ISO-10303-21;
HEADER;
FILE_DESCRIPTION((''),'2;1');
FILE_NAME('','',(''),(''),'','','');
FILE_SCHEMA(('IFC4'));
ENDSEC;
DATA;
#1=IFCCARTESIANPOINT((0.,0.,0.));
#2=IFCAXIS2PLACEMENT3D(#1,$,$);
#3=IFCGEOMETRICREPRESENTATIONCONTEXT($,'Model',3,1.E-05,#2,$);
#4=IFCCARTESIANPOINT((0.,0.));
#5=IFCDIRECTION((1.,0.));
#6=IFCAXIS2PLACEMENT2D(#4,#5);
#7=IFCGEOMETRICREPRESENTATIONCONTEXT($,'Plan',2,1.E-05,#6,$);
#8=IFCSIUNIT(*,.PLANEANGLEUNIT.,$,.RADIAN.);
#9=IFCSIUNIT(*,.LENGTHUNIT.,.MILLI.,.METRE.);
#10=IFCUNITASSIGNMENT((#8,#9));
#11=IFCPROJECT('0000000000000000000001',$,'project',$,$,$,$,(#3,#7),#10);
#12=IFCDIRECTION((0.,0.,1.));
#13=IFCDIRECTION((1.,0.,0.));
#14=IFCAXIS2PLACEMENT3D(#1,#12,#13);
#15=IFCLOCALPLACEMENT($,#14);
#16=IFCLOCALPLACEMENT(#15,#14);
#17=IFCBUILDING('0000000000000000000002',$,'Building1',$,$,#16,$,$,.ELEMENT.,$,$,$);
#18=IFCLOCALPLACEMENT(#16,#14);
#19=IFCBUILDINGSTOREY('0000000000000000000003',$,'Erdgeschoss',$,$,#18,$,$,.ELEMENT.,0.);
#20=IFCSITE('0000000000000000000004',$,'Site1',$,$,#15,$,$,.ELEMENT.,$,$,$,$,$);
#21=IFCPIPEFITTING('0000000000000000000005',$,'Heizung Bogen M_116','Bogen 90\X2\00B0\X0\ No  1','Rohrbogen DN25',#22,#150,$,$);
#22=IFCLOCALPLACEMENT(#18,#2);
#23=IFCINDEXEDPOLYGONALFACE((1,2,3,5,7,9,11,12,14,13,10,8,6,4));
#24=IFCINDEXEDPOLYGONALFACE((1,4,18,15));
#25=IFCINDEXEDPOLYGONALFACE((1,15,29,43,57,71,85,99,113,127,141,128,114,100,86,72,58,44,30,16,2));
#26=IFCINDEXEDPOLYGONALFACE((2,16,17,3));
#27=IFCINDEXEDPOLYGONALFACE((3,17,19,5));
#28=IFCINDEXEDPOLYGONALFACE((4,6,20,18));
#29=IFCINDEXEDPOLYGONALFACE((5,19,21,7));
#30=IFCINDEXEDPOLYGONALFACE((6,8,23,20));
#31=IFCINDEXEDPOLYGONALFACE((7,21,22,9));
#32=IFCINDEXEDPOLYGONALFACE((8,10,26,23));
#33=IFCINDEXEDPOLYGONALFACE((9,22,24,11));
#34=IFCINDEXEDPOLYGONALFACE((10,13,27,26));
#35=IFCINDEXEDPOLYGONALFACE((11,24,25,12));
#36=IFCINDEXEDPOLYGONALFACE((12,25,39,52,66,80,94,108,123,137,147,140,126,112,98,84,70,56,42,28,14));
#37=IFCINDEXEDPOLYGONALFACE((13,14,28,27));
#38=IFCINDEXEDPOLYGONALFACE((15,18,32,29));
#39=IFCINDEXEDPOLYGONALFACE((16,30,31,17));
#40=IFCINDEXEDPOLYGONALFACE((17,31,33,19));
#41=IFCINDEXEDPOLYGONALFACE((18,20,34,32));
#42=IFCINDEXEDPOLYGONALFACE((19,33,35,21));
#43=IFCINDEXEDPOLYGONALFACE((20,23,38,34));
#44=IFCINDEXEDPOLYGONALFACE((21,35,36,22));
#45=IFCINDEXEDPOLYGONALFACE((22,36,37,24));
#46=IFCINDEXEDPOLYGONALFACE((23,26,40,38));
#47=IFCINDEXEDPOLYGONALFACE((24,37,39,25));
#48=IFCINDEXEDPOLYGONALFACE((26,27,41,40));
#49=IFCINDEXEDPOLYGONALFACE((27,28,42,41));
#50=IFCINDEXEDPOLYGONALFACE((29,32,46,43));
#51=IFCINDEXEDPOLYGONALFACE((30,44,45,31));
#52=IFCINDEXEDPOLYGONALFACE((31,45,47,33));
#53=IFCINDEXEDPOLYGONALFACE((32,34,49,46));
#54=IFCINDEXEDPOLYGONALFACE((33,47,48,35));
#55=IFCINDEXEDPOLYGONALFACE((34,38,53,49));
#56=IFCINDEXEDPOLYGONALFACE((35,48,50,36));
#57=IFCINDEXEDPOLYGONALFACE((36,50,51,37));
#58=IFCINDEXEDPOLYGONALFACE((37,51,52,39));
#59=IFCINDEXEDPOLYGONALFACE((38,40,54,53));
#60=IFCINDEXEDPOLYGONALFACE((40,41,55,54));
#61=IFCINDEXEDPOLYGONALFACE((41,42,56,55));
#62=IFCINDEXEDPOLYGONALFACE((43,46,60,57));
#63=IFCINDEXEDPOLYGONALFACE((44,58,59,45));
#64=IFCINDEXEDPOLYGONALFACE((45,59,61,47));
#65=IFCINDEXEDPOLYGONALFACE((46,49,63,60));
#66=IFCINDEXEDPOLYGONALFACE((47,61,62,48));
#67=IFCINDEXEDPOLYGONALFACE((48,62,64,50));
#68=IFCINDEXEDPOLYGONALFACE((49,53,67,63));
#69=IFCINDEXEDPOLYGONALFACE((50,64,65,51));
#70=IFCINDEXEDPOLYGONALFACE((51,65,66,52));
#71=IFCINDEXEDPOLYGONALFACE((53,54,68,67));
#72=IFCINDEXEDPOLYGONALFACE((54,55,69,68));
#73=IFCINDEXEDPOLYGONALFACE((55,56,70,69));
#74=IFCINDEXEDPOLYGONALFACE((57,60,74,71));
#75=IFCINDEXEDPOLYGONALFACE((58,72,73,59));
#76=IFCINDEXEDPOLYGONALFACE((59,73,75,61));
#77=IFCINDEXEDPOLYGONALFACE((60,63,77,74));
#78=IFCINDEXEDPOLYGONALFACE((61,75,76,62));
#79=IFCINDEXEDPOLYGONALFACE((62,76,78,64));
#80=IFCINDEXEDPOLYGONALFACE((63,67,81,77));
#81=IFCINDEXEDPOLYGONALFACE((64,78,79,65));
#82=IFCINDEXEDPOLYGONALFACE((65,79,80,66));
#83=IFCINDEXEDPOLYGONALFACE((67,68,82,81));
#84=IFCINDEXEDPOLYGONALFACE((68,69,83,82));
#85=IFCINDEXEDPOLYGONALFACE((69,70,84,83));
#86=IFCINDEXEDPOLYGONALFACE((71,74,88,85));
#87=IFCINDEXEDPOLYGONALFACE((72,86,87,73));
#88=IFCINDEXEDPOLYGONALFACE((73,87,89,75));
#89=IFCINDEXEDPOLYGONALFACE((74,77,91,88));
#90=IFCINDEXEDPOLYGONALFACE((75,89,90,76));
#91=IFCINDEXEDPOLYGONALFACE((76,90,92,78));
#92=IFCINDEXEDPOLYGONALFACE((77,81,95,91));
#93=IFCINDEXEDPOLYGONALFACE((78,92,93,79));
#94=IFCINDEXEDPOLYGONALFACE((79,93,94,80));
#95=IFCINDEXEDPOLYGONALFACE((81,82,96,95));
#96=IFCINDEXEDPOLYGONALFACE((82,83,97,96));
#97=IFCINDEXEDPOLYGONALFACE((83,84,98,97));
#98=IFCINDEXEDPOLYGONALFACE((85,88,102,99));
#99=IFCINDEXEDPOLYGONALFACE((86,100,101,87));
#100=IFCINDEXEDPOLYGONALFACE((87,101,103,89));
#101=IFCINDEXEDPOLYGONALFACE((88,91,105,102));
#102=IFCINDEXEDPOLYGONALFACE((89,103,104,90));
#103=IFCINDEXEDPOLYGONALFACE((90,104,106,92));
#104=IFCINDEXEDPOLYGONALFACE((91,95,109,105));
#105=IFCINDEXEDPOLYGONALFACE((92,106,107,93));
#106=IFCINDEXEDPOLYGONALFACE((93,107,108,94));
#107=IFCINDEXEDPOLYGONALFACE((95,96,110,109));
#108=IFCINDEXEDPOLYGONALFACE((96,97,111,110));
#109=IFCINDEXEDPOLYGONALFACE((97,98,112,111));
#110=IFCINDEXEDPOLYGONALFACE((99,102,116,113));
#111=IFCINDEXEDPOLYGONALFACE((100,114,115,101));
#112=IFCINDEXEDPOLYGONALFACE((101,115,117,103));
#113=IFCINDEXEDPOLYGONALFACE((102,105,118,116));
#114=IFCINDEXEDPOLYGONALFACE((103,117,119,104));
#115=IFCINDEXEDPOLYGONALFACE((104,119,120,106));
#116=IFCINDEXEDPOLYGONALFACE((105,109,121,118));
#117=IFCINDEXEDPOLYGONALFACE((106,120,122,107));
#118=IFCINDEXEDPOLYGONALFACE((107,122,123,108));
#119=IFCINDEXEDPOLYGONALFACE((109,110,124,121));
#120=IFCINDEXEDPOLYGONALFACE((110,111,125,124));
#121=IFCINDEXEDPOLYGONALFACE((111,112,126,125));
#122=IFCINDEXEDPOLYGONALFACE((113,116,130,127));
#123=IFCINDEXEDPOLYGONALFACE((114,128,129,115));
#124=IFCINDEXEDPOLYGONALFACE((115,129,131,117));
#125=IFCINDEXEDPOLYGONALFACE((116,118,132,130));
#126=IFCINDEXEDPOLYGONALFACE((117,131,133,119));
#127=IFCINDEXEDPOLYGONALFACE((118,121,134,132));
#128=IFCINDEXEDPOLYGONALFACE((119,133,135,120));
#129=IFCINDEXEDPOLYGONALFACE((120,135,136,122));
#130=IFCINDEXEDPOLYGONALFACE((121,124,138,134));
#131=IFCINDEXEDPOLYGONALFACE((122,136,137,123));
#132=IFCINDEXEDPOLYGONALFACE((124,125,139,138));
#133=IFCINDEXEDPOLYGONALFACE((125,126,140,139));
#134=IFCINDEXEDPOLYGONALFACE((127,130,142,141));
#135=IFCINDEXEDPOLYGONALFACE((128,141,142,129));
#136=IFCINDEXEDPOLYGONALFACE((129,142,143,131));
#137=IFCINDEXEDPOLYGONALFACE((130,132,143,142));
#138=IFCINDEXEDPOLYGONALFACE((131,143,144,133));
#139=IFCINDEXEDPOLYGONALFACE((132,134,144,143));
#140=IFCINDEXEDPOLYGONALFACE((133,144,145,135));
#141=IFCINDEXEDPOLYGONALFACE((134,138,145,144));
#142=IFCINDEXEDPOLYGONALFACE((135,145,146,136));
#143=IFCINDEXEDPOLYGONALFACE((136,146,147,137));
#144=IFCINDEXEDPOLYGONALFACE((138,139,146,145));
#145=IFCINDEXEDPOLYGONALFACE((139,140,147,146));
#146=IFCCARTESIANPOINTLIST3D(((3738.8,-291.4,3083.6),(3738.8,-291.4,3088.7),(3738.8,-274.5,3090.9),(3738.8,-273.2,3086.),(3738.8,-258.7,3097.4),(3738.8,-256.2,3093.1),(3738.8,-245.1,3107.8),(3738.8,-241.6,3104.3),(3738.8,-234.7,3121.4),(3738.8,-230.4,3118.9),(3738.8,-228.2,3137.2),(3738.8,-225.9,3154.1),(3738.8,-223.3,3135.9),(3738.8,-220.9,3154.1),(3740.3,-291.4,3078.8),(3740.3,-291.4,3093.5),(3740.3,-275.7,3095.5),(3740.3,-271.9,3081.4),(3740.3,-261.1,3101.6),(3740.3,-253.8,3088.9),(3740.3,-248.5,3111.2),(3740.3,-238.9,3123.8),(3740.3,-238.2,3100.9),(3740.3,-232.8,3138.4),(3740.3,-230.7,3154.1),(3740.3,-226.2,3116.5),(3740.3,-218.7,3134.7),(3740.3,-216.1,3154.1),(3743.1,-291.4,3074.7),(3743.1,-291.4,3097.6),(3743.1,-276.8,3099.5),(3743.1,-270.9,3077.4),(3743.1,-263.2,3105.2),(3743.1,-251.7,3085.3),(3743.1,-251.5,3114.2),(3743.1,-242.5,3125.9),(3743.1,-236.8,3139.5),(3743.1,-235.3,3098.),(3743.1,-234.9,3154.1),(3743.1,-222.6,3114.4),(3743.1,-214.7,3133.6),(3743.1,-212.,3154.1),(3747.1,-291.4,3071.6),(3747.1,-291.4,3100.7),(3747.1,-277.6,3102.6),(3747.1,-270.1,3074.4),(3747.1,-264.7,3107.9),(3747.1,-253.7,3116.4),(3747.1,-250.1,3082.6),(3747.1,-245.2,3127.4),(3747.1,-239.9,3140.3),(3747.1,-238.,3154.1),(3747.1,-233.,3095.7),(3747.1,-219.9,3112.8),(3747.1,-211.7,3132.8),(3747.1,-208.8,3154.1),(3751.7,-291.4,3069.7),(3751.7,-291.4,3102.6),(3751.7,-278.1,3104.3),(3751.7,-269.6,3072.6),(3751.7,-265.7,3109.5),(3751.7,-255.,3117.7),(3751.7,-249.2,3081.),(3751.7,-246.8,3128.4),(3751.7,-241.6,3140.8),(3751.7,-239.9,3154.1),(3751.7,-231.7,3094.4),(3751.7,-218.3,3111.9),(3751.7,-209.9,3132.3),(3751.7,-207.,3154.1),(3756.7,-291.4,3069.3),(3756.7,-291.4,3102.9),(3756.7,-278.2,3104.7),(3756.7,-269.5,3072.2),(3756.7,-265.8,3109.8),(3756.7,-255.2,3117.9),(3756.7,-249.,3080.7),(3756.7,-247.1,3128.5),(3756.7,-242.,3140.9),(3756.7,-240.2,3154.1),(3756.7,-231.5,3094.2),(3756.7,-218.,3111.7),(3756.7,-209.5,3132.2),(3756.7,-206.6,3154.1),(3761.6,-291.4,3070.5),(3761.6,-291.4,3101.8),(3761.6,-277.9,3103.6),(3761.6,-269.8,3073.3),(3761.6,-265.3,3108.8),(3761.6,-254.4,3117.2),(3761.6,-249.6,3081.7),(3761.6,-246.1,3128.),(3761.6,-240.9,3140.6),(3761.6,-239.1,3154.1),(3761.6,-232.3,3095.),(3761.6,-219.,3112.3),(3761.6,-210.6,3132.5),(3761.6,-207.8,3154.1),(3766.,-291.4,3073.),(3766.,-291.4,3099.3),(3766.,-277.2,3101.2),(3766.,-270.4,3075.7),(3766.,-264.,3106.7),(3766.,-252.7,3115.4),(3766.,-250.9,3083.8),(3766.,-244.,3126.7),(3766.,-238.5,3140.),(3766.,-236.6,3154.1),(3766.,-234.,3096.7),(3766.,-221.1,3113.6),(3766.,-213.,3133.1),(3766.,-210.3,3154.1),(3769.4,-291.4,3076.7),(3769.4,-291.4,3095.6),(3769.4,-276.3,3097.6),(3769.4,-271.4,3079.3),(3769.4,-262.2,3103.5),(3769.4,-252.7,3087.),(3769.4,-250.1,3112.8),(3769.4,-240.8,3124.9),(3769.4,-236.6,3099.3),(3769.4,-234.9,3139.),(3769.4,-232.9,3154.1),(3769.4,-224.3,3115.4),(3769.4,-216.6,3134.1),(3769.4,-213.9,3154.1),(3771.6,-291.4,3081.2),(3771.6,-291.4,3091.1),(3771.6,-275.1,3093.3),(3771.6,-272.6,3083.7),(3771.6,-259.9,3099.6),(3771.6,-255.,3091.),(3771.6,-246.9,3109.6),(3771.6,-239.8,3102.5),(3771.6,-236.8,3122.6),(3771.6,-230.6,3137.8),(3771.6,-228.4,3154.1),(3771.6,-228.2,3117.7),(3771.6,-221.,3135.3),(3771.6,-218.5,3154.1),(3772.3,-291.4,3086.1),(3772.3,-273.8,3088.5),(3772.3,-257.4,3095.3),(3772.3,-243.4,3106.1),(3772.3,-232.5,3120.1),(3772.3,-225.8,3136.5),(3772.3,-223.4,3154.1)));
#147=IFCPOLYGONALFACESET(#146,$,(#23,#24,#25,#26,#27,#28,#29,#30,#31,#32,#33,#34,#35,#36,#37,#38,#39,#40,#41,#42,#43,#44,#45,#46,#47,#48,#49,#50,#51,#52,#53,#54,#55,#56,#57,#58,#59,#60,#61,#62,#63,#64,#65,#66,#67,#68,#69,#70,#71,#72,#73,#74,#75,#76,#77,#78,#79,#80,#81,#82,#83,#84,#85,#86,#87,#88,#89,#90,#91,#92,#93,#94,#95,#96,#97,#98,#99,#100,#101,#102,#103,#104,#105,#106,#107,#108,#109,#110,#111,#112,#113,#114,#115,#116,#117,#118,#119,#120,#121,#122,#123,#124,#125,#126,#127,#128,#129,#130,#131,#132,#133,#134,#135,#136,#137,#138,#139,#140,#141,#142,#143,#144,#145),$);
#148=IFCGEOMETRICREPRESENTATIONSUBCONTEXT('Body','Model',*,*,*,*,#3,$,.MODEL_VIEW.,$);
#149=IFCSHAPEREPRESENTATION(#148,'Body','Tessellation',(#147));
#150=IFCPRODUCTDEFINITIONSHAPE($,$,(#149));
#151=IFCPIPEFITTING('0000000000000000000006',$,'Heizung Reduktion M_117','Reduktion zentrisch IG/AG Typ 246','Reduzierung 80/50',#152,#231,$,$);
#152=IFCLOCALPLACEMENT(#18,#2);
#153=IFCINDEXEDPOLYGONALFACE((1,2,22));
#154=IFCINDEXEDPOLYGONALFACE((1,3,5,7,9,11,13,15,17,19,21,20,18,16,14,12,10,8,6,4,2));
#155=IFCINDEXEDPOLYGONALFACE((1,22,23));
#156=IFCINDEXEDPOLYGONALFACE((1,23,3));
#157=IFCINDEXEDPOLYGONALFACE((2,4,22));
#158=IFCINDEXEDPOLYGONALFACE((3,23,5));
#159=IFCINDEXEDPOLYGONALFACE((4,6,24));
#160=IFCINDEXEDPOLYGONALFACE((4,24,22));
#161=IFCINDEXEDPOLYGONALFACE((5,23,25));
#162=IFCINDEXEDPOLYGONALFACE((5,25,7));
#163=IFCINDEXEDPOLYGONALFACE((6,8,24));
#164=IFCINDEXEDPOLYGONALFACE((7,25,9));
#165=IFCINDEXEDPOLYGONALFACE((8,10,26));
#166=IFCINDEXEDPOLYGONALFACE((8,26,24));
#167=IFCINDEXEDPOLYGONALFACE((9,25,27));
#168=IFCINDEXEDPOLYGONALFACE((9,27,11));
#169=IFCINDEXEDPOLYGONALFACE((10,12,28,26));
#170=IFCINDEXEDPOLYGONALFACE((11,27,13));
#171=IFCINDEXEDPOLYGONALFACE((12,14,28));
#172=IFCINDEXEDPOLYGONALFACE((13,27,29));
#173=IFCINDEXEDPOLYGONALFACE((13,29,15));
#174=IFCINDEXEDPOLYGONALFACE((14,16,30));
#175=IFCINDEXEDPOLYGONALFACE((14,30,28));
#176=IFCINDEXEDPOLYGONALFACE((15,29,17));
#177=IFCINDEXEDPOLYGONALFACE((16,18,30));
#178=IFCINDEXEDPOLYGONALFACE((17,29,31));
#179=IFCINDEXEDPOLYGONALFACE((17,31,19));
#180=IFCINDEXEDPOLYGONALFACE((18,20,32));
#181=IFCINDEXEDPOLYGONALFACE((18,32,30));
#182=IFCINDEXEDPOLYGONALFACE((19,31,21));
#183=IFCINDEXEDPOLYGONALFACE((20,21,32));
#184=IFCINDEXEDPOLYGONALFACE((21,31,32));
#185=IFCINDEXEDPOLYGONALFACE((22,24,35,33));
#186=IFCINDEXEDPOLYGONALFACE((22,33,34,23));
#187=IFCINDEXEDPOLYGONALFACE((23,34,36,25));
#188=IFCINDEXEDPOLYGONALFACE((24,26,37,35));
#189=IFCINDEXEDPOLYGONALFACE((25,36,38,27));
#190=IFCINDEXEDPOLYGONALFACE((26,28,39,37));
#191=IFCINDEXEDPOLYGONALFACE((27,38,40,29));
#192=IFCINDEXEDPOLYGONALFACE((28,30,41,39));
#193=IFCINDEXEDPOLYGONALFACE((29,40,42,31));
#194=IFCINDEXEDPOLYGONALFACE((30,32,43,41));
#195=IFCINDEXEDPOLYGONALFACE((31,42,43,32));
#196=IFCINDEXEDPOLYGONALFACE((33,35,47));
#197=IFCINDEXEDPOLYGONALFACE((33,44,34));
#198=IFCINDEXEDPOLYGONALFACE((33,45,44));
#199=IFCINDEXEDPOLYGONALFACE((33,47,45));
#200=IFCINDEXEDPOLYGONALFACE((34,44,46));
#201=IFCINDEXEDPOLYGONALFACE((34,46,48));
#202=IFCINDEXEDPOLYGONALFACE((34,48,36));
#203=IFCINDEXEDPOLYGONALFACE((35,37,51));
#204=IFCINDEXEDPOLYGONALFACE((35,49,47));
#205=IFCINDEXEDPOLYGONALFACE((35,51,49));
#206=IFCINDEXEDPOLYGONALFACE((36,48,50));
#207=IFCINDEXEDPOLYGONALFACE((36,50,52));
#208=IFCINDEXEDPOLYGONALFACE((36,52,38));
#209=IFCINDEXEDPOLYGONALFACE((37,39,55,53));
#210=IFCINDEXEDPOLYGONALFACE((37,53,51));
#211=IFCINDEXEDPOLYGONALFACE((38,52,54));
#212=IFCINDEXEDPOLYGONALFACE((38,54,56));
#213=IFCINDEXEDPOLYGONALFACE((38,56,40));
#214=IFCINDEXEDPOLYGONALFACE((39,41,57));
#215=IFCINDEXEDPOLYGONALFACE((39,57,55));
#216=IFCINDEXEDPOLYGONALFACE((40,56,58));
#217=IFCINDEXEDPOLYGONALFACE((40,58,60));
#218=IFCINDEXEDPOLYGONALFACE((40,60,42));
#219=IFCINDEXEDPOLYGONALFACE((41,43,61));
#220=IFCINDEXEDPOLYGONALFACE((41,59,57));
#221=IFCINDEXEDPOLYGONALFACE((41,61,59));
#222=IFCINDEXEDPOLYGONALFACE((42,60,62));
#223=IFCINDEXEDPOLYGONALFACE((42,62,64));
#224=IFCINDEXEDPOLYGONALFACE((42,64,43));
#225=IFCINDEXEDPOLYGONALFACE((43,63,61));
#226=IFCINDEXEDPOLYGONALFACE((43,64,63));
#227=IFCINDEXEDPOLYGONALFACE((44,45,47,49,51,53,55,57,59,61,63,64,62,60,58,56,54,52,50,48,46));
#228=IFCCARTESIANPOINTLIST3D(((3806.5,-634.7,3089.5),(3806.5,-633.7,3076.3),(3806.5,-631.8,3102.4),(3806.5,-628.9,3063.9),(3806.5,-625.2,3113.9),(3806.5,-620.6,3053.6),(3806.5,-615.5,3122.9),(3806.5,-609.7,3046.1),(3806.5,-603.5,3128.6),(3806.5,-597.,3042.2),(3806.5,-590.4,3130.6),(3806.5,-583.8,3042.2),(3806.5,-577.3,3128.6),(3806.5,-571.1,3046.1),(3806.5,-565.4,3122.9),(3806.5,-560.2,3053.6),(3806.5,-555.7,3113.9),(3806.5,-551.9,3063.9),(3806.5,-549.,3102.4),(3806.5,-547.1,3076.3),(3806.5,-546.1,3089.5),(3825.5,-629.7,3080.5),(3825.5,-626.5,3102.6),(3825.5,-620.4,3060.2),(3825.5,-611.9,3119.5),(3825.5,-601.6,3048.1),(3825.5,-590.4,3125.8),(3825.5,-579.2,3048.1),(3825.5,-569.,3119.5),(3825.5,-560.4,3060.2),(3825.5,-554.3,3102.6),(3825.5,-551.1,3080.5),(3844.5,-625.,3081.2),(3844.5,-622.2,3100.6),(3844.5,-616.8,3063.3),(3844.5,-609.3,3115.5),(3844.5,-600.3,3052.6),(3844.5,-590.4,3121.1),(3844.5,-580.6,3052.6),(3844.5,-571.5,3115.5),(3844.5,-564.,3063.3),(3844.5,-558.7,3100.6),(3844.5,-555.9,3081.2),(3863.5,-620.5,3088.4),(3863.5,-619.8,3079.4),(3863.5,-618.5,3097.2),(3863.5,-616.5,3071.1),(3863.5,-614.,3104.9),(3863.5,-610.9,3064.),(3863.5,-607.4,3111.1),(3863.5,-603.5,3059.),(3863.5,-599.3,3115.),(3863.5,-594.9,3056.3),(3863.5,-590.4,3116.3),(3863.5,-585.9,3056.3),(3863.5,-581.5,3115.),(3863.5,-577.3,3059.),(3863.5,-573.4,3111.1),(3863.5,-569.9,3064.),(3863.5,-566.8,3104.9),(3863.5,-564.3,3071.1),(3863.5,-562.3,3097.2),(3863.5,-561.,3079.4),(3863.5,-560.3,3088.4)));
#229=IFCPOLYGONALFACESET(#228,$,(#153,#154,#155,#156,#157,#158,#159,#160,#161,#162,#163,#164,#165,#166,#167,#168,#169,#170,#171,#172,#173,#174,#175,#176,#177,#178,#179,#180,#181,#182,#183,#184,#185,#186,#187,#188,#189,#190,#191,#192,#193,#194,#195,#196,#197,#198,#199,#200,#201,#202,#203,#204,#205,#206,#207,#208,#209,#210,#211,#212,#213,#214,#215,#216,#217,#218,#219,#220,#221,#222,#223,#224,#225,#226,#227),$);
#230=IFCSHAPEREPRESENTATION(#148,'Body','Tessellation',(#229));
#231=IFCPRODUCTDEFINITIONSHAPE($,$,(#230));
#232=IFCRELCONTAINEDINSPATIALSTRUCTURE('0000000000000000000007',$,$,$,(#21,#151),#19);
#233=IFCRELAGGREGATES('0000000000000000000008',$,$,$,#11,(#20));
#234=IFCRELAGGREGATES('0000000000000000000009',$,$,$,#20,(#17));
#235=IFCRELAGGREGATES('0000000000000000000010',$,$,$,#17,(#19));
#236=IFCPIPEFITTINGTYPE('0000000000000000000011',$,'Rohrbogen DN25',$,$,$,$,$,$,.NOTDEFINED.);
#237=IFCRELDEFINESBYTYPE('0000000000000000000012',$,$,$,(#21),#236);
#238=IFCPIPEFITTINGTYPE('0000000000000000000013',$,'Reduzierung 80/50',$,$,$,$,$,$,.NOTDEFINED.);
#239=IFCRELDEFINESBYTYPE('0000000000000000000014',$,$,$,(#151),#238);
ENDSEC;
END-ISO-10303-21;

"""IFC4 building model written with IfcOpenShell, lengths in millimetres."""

from ifc_helpers import new_model, entity, si_unit, frame, origin, origin_with_axes, origin_2d_with_axis, place, context, subcontext, project, spatial, source, transform, mapped, type_object, element, save


model = new_model("IFC4")

# Units and contexts
model_context = context("Model", 3, precision=1e-05, world=origin())
plan_context = context("Plan", 2, precision=1e-05, world=origin_2d_with_axis())
body_context = subcontext(model_context, "Body", "Model", "MODEL_VIEW")
ifc_project = project(units=[si_unit("PLANEANGLEUNIT", "RADIAN"), si_unit("LENGTHUNIT", "METRE", prefix="MILLI")], contexts=[model_context, plan_context])

# Site, building, storey
site_placement = place(None, origin_with_axes())
site = spatial("IfcSite", under=ifc_project, at=site_placement, Name="Site1", CompositionType="ELEMENT")
building_placement = place(site_placement, origin_with_axes())
building = spatial("IfcBuilding", under=site, at=building_placement, Name="Building1", CompositionType="ELEMENT")
storey_placement = place(building_placement, origin_with_axes())
storey = spatial("IfcBuildingStorey", under=building, at=storey_placement, Name="Erdgeschoss", CompositionType="ELEMENT", Elevation=0.0)

# Pipe fittings
pipe_fitting_type_1 = type_object("IfcPipeFittingType", Name="Rohrbogen DN25", PredefinedType="NOTDEFINED")
ifc_direction_1 = entity("IfcDirection", [-1.0, 0.0, 0.0])
shared_shape_1 = source(origin_with_axes(), body_context, "Body", "SolidModel", [
    entity("IfcRevolvedAreaSolid", entity("IfcCircleProfileDef", "AREA", None, entity("IfcAxis2Placement2D", entity("IfcCartesianPoint", [0.0, 0.0]), entity("IfcDirection", [1.0, 0.0])), 16.9), entity("IfcAxis2Placement3D", entity("IfcCartesianPoint", [42.4, 25.6, 0.0]), ifc_direction_1, entity("IfcDirection", [0.0, 0.0, -1.0])), entity("IfcAxis1Placement", entity("IfcCartesianPoint", [0.0, 68.0, 0.0]), ifc_direction_1), 1.570796),
])
pipe_fitting_1_placement = place(storey_placement, frame((3755.5, -249.0, 3111.7), z_axis=(0.0, 0.0, 1.0), x_axis=(1.0, 0.0, 0.0)))
element("IfcPipeFitting", 1, at=pipe_fitting_1_placement, inside=storey, type_object=pipe_fitting_type_1, Name="Heizung Bogen M_116", Description="Bogen 90° No  1", ObjectType="Rohrbogen DN25", context=body_context, shape_type="MappedRepresentation", body=[
    mapped(shared_shape_1, transform((0.0, 0.0, 0.0), x_axis=(0.0, 0.0, 1.0), y_axis=(0.0, 1.0, 0.0), z_axis=(-1.0, 0.0, 0.0), scale=1.0)),
])
pipe_fitting_type_2 = type_object("IfcPipeFittingType", Name="Reduzierung 80/50", PredefinedType="NOTDEFINED")
axis2_placement2_d = entity("IfcAxis2Placement2D", entity("IfcCartesianPoint", [0.0, 0.0]), entity("IfcDirection", [1.0, 0.0]))
ifc_direction_2 = entity("IfcDirection", [0.0, 0.0, 1.0])
shared_shape_2 = source(origin_with_axes(), body_context, "Body", "SolidModel", [
    entity("IfcExtrudedAreaSolidTapered", entity("IfcCircleProfileDef", "AREA", None, axis2_placement2_d, 44.5), entity("IfcAxis2Placement3D", entity("IfcCartesianPoint", [-28.5, -0.1, 0.0]), entity("IfcDirection", [1.0, 0.0, 0.0]), ifc_direction_2), ifc_direction_2, 57.0, entity("IfcCircleProfileDef", "AREA", None, axis2_placement2_d, 30.1)),
])
pipe_fitting_2_placement = place(storey_placement, frame((3835.0, -590.3, 3086.1), z_axis=(0.0, 0.0, 1.0), x_axis=(1.0, 0.0, 0.0)))
element("IfcPipeFitting", 2, at=pipe_fitting_2_placement, inside=storey, type_object=pipe_fitting_type_2, Name="Heizung Reduktion M_117", Description="Reduktion zentrisch IG/AG Typ 246", ObjectType="Reduzierung 80/50", context=body_context, shape_type="MappedRepresentation", body=[
    mapped(shared_shape_2, transform((0.0, 0.0, 0.0), x_axis=(1.0, 0.0, 0.0), y_axis=(0.0, 1.0, 0.0), z_axis=(0.0, 0.0, 1.0), scale=1.0)),
])

save(model, "model.ifc")
